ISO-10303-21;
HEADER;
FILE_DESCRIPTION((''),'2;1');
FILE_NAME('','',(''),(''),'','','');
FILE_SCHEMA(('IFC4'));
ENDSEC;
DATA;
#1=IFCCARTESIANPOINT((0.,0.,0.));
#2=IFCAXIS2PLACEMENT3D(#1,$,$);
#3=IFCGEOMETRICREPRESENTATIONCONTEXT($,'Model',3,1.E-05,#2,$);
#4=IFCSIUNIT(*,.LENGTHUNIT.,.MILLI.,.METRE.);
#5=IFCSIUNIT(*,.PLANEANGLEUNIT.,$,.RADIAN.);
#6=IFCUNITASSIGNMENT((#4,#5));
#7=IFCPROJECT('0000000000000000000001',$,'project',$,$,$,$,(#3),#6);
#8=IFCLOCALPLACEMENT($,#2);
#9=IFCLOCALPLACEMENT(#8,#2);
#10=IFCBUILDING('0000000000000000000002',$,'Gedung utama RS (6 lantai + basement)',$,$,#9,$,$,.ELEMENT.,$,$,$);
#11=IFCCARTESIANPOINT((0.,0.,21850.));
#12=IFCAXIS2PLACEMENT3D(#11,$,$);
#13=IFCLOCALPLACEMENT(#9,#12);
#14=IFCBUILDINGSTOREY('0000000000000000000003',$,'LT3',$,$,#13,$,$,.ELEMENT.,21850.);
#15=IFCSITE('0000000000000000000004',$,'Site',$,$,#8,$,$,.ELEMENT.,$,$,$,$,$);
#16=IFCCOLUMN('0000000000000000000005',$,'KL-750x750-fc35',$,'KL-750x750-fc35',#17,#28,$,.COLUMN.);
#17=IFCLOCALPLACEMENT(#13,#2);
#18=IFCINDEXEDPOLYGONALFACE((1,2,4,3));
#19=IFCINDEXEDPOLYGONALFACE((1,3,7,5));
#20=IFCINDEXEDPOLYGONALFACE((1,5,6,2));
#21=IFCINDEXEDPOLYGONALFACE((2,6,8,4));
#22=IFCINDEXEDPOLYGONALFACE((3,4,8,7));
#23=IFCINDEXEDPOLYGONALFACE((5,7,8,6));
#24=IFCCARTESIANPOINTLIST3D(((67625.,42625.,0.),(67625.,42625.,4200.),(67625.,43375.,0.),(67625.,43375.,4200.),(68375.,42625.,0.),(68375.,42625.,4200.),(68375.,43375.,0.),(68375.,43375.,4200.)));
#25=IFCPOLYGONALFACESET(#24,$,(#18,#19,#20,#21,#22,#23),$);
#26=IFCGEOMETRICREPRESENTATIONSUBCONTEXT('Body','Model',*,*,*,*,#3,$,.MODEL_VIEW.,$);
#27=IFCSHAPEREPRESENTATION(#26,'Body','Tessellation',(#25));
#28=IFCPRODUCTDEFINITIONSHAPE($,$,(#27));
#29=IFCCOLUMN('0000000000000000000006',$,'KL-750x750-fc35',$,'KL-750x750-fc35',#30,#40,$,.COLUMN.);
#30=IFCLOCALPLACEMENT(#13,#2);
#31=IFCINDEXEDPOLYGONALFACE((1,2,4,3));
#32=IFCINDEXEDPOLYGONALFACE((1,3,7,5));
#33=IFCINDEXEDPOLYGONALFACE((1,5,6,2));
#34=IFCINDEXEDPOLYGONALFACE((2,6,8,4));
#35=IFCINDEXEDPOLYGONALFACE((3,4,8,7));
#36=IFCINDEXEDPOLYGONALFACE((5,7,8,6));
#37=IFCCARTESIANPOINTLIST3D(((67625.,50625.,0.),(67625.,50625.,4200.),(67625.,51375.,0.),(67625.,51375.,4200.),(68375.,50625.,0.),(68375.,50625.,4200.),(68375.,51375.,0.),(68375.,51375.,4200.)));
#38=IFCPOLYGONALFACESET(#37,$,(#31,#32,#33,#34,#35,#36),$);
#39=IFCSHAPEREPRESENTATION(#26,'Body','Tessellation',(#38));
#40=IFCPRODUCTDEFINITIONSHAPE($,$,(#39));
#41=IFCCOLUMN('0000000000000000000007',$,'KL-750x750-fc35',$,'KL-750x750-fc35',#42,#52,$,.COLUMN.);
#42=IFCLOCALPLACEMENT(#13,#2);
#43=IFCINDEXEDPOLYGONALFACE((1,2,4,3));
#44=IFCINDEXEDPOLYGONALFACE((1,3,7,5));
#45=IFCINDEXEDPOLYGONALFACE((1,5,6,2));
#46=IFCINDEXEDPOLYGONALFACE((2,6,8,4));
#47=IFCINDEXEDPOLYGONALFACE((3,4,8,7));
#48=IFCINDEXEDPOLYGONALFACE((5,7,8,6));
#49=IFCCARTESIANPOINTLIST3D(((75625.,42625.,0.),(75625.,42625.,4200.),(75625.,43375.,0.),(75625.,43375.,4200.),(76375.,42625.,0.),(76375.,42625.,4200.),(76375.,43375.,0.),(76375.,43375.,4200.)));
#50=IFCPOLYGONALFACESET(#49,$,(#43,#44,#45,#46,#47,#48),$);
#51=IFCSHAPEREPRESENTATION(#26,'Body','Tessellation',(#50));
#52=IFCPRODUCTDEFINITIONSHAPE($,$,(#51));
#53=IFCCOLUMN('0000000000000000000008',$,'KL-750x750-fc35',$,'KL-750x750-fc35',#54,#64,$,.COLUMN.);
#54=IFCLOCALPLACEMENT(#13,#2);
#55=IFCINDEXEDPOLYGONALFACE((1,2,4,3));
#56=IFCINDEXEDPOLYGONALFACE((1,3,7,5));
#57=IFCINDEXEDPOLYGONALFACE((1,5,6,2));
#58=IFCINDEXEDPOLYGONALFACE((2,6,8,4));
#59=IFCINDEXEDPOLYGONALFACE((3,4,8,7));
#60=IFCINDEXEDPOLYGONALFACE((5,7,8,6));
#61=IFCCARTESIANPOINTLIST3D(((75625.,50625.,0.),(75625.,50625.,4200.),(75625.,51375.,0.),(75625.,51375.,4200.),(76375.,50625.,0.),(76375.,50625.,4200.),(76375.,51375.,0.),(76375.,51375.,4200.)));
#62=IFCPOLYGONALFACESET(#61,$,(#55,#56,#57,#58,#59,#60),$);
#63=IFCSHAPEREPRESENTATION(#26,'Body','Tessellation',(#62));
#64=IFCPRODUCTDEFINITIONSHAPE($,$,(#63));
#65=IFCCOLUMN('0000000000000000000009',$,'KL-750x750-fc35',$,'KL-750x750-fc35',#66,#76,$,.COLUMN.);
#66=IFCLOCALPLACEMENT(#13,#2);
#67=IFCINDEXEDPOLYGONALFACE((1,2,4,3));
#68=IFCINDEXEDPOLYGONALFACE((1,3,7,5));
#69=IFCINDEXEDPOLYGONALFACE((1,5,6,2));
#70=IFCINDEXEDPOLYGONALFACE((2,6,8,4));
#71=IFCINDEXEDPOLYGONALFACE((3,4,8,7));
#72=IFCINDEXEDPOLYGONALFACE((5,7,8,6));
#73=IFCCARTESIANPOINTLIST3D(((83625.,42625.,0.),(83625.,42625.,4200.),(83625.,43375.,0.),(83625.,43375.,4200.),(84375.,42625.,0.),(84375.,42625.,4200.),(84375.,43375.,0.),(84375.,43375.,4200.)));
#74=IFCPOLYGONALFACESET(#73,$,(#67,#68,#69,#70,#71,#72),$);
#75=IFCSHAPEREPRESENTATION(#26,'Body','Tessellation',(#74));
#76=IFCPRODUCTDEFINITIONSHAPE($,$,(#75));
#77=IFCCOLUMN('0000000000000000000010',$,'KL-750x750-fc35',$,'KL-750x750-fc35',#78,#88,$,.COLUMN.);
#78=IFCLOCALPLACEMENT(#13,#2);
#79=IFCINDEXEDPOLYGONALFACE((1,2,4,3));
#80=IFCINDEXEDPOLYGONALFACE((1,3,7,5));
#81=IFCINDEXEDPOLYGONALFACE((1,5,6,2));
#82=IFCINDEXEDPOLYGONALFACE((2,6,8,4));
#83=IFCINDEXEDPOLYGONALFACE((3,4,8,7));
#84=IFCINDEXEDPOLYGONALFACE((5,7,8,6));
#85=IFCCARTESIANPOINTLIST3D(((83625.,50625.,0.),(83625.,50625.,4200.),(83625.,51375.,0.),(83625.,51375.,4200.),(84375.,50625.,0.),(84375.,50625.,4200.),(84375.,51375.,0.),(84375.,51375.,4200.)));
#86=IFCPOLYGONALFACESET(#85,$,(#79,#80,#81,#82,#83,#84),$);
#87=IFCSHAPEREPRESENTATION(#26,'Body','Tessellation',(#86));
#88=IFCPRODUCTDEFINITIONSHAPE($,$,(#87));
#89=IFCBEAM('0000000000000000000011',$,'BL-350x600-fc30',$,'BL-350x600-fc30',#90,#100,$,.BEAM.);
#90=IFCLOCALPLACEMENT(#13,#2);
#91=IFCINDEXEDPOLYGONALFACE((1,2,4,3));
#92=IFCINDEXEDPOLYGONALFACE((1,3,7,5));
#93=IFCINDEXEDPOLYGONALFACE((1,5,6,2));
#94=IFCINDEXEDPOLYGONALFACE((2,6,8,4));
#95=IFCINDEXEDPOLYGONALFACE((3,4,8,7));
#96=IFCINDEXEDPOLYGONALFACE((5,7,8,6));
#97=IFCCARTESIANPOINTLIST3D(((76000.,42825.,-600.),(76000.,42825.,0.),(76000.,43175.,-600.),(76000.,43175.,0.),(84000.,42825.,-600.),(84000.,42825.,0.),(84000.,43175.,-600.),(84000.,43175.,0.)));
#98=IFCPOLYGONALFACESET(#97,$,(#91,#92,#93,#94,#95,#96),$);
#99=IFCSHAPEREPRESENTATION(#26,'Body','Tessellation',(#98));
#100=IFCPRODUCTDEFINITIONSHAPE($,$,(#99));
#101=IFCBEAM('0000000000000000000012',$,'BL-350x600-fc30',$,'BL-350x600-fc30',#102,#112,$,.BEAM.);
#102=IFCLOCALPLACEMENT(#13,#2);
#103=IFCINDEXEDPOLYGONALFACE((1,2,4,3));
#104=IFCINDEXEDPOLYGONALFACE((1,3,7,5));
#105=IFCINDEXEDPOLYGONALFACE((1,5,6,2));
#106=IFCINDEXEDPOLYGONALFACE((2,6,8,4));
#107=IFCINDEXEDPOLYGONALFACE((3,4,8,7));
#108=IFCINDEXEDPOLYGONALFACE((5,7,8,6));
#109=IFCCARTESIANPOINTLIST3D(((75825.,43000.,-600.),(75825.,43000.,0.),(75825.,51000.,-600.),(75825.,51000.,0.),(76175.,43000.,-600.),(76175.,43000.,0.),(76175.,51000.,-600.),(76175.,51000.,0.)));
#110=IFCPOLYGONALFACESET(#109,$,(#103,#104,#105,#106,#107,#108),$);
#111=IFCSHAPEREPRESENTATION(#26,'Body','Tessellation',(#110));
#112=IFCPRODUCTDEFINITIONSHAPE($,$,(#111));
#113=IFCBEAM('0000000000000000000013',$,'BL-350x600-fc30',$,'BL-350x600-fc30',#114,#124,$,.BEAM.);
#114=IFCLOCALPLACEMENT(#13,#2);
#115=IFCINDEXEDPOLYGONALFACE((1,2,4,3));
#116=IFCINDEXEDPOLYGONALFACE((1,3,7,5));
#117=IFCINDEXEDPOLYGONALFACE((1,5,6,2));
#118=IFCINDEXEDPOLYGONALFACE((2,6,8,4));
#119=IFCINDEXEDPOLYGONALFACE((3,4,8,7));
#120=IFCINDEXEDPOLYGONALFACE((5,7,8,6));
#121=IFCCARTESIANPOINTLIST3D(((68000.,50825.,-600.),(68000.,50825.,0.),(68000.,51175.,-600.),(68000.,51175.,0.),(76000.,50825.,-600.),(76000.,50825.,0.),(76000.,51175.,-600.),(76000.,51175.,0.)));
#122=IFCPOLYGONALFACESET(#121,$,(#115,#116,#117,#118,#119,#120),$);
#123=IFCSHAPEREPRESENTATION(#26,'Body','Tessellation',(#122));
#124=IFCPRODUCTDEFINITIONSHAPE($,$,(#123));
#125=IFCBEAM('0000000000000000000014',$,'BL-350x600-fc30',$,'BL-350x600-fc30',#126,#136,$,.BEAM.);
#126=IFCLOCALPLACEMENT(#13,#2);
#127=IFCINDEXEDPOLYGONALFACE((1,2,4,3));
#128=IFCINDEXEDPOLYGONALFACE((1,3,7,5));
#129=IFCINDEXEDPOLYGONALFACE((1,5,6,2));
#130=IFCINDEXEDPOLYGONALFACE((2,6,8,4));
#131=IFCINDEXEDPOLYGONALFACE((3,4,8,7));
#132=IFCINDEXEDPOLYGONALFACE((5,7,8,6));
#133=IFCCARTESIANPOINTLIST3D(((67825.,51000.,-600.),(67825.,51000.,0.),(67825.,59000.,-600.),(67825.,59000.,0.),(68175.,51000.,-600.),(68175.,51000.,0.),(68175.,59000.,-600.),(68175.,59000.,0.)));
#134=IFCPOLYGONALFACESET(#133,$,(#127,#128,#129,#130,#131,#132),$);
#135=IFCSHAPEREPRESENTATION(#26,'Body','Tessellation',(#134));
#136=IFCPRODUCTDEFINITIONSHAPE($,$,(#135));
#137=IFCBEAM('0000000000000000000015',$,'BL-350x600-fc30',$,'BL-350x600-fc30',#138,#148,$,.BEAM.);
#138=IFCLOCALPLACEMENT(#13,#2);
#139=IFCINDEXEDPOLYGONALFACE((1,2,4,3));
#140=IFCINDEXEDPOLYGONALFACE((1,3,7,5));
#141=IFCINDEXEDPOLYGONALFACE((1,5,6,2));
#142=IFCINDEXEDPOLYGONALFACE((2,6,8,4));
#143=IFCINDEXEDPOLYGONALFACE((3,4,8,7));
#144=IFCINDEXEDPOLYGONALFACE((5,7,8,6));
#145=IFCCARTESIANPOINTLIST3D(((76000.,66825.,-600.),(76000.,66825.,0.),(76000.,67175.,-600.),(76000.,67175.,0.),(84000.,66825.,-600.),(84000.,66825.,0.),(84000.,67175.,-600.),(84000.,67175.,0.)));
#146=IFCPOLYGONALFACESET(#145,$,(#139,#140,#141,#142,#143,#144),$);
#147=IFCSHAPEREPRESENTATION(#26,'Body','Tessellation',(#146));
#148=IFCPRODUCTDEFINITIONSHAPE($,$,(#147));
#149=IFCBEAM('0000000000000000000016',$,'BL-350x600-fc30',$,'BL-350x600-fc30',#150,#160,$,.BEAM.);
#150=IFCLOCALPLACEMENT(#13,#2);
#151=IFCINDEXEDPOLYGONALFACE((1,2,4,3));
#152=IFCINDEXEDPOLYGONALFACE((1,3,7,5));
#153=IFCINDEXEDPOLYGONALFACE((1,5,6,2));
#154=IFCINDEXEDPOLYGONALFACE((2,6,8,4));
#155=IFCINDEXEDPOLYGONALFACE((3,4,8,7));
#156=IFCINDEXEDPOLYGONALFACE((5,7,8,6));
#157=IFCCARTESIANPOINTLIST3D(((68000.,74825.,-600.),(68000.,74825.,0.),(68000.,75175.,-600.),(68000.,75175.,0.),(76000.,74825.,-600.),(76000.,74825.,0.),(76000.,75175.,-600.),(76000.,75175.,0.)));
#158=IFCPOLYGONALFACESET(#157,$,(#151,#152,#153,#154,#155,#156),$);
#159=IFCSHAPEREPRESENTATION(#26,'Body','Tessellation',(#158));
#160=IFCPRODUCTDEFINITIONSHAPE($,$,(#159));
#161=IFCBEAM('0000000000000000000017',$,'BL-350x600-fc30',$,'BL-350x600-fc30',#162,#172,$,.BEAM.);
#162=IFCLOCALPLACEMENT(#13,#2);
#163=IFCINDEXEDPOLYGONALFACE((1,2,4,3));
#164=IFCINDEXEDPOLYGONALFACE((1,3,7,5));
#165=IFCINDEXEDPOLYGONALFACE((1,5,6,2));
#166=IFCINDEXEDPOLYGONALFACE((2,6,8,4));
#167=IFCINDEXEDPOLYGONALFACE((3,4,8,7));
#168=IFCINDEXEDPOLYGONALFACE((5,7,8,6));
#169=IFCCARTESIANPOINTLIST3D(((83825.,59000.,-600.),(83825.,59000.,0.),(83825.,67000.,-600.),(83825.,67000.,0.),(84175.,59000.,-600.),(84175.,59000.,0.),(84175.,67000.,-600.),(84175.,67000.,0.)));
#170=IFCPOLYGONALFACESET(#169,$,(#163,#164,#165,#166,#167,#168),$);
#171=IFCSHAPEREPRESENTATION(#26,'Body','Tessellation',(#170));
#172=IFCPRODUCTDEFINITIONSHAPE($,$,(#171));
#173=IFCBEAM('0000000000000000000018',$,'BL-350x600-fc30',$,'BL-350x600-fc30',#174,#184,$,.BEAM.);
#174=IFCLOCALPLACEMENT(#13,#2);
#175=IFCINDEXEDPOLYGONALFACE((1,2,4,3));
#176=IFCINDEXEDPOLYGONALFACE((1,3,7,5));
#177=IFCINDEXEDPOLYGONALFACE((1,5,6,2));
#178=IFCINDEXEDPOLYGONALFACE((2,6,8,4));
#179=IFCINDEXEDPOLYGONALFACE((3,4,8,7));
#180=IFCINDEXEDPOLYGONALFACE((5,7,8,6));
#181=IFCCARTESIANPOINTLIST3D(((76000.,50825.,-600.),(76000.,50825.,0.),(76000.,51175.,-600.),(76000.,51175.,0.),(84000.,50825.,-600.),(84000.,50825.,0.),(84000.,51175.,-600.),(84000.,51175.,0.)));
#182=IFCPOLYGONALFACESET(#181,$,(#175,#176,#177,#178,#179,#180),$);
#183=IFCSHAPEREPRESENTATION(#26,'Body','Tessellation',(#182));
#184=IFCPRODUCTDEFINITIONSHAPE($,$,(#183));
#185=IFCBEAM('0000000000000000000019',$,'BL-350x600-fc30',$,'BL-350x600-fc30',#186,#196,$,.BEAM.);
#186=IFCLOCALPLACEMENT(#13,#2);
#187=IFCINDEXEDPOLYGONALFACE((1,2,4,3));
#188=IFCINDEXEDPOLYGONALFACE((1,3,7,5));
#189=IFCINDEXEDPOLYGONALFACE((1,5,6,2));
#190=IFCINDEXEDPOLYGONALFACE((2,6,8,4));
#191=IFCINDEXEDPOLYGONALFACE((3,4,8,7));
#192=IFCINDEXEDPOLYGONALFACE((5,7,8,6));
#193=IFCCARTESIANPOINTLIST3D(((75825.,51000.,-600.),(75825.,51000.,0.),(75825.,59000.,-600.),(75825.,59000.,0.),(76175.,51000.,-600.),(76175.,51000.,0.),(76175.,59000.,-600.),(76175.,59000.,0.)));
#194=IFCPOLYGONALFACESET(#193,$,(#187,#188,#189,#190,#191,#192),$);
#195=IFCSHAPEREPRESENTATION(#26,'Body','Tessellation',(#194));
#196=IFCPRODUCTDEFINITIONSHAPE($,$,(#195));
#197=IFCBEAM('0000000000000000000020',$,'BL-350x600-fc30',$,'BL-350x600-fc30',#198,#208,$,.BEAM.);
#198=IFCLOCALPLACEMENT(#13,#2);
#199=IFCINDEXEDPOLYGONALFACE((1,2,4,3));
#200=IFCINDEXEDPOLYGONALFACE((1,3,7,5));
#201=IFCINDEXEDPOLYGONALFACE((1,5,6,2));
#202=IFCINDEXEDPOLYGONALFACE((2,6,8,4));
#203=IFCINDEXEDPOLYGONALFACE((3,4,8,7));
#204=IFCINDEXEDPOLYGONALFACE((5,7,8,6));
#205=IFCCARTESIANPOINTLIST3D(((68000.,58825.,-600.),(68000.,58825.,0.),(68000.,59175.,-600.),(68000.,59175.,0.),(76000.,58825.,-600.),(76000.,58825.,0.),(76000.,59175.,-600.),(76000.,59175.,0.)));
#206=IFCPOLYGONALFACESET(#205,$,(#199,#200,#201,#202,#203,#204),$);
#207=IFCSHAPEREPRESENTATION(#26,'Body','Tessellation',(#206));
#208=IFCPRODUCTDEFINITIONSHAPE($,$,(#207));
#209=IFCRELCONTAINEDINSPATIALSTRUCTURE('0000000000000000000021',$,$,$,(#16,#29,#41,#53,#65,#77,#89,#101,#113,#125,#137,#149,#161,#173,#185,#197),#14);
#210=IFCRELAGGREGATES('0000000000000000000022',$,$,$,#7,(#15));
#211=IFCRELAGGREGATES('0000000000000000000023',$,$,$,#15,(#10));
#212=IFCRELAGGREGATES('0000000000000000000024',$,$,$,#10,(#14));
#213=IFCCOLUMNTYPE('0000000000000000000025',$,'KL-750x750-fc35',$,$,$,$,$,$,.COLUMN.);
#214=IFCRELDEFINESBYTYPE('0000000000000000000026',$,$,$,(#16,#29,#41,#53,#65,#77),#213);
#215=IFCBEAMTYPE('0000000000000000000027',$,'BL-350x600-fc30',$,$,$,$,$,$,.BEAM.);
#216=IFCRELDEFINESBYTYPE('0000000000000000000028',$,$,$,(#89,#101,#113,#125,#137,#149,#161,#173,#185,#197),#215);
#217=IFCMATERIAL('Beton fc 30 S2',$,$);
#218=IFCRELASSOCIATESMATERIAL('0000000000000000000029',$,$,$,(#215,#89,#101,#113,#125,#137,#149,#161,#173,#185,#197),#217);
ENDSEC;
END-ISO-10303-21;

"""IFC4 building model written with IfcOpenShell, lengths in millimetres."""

from ifc_helpers import new_model, si_unit, frame, origin, origin_2d, place, context, subcontext, project, spatial, rectangle, extrude, material, material_profile, profile_set, profile_usage, type_object, element, save


model = new_model("IFC4")

# Units and contexts
model_context = context("Model", 3, precision=1e-05, world=origin())
body_context = subcontext(model_context, "Body", "Model", "MODEL_VIEW")
ifc_project = project(units=[si_unit("LENGTHUNIT", "METRE", prefix="MILLI"), si_unit("PLANEANGLEUNIT", "RADIAN")], contexts=[model_context])

# Site, building, storey
site_placement = place(None, origin())
site = spatial("IfcSite", under=ifc_project, at=site_placement, Name="Site", CompositionType="ELEMENT")
building_placement = place(site_placement, origin())
building = spatial("IfcBuilding", under=site, at=building_placement, Name="Gedung utama RS (6 lantai + basement)", CompositionType="ELEMENT")
storey_placement = place(building_placement, frame((0.0, 0.0, 21850.0)))
storey = spatial("IfcBuildingStorey", under=building, at=storey_placement, Name="LT3", CompositionType="ELEMENT", Elevation=21850.0)

# Columns
ifc_material_profile_1 = material_profile(None, rectangle(XDim=750.0, YDim=750.0, at=origin_2d()), Name="KL-750x750-fc35")
ifc_profile_set_1 = profile_set([ifc_material_profile_1], Name="KL-750x750-fc35")
ifc_profile_usage_1 = profile_usage(ifc_profile_set_1, cardinal=5)
column_type = type_object("IfcColumnType", Name="KL-750x750-fc35", PredefinedType="COLUMN", material=ifc_profile_set_1)
for number, where, z_axis, x_axis, name in (
    (1, (68000.0, 43000.0, 0.0), (0.0, 0.0, 1.0), (1.0, 0.0, 0.0), "KL-750x750-fc35"),
    (2, (68000.0, 51000.0, 0.0), (0.0, 0.0, 1.0), (1.0, 0.0, 0.0), "KL-750x750-fc35"),
    (3, (76000.0, 43000.0, 0.0), (0.0, 0.0, 1.0), (1.0, 0.0, 0.0), "KL-750x750-fc35"),
    (4, (76000.0, 51000.0, 0.0), (0.0, 0.0, 1.0), (1.0, 0.0, 0.0), "KL-750x750-fc35"),
    (5, (84000.0, 43000.0, 0.0), (0.0, 0.0, 1.0), (1.0, 0.0, 0.0), "KL-750x750-fc35"),
    (6, (84000.0, 51000.0, 0.0), (0.0, 0.0, 1.0), (1.0, 0.0, 0.0), "KL-750x750-fc35"),
):
    element("IfcColumn", number, at=place(storey_placement, frame(where, z_axis=z_axis, x_axis=x_axis)), inside=storey, type_object=column_type, material=ifc_profile_usage_1, Name=name, ObjectType="KL-750x750-fc35", PredefinedType="COLUMN", context=body_context, shape_type="SweptSolid", body=[
        extrude(rectangle(XDim=750.0, YDim=750.0, at=origin_2d()), origin(), (0.0, 0.0, 1.0), 4200.0),
    ])

# Beams
ifc_material = material(Name="Beton fc 30 S2")
ifc_material_profile_2 = material_profile(ifc_material, rectangle(XDim=350.0, YDim=600.0, at=origin_2d()), Name="BL-350x600-fc30")
ifc_profile_set_2 = profile_set([ifc_material_profile_2], Name="BL-350x600-fc30")
ifc_profile_usage_2 = profile_usage(ifc_profile_set_2, cardinal=8)
beam_type_1 = type_object("IfcBeamType", Name="BL-350x600-fc30", PredefinedType="BEAM", material=ifc_profile_set_2)
beam_1_placement = place(storey_placement, frame((76000.0, 43000.0, -300.0)))
element("IfcBeam", 7, at=beam_1_placement, inside=storey, type_object=beam_type_1, material=ifc_profile_usage_2, Name="BL-350x600-fc30", ObjectType="BL-350x600-fc30", PredefinedType="BEAM", context=body_context, shape_type="SweptSolid", body=[
    extrude(rectangle(XDim=350.0, YDim=600.0, at=origin_2d()), frame((0.0, 0.0, 0.0), z_axis=(1.0, 0.0, 0.0), x_axis=(0.0, 1.0, 0.0)), (0.0, 0.0, 1.0), 8000.0),
])
beam_2_placement = place(storey_placement, frame((76000.0, 43000.0, -300.0)))
element("IfcBeam", 8, at=beam_2_placement, inside=storey, type_object=beam_type_1, material=ifc_profile_usage_2, Name="BL-350x600-fc30", ObjectType="BL-350x600-fc30", PredefinedType="BEAM", context=body_context, shape_type="SweptSolid", body=[
    extrude(rectangle(XDim=350.0, YDim=600.0, at=origin_2d()), frame((0.0, 0.0, 0.0), z_axis=(0.0, 1.0, 0.0), x_axis=(-1.0, 0.0, 0.0)), (0.0, 0.0, 1.0), 8000.0),
])
beam_3_placement = place(storey_placement, frame((68000.0, 51000.0, -300.0)))
element("IfcBeam", 9, at=beam_3_placement, inside=storey, type_object=beam_type_1, material=ifc_profile_usage_2, Name="BL-350x600-fc30", ObjectType="BL-350x600-fc30", PredefinedType="BEAM", context=body_context, shape_type="SweptSolid", body=[
    extrude(rectangle(XDim=350.0, YDim=600.0, at=origin_2d()), frame((0.0, 0.0, 0.0), z_axis=(1.0, 0.0, 0.0), x_axis=(0.0, 1.0, 0.0)), (0.0, 0.0, 1.0), 8000.0),
])
beam_4_placement = place(storey_placement, frame((68000.0, 51000.0, -300.0)))
element("IfcBeam", 10, at=beam_4_placement, inside=storey, type_object=beam_type_1, material=ifc_profile_usage_2, Name="BL-350x600-fc30", ObjectType="BL-350x600-fc30", PredefinedType="BEAM", context=body_context, shape_type="SweptSolid", body=[
    extrude(rectangle(XDim=350.0, YDim=600.0, at=origin_2d()), frame((0.0, 0.0, 0.0), z_axis=(0.0, 1.0, 0.0), x_axis=(-1.0, 0.0, 0.0)), (0.0, 0.0, 1.0), 8000.0),
])
for number, where, name in (
    (11, (76000.0, 67000.0, -300.0), "BL-350x600-fc30"),
    (12, (68000.0, 75000.0, -300.0), "BL-350x600-fc30"),
):
    element("IfcBeam", number, at=place(storey_placement, frame(where)), inside=storey, type_object=beam_type_1, material=ifc_profile_usage_2, Name=name, ObjectType="BL-350x600-fc30", PredefinedType="BEAM", context=body_context, shape_type="SweptSolid", body=[
        extrude(rectangle(XDim=350.0, YDim=600.0, at=origin_2d()), frame((0.0, 0.0, 0.0), z_axis=(1.0, 0.0, 0.0), x_axis=(0.0, 1.0, 0.0)), (0.0, 0.0, 1.0), 8000.0),
    ])
beam_5_placement = place(storey_placement, frame((84000.0, 59000.0, -300.0)))
element("IfcBeam", 13, at=beam_5_placement, inside=storey, type_object=beam_type_1, material=ifc_profile_usage_2, Name="BL-350x600-fc30", ObjectType="BL-350x600-fc30", PredefinedType="BEAM", context=body_context, shape_type="SweptSolid", body=[
    extrude(rectangle(XDim=350.0, YDim=600.0, at=origin_2d()), frame((0.0, 0.0, 0.0), z_axis=(0.0, 1.0, 0.0), x_axis=(-1.0, 0.0, 0.0)), (0.0, 0.0, 1.0), 8000.0),
])
beam_6_placement = place(storey_placement, frame((76000.0, 51000.0, -300.0)))
element("IfcBeam", 14, at=beam_6_placement, inside=storey, type_object=beam_type_1, material=ifc_profile_usage_2, Name="BL-350x600-fc30", ObjectType="BL-350x600-fc30", PredefinedType="BEAM", context=body_context, shape_type="SweptSolid", body=[
    extrude(rectangle(XDim=350.0, YDim=600.0, at=origin_2d()), frame((0.0, 0.0, 0.0), z_axis=(1.0, 0.0, 0.0), x_axis=(0.0, 1.0, 0.0)), (0.0, 0.0, 1.0), 8000.0),
])
beam_7_placement = place(storey_placement, frame((76000.0, 51000.0, -300.0)))
element("IfcBeam", 15, at=beam_7_placement, inside=storey, type_object=beam_type_1, material=ifc_profile_usage_2, Name="BL-350x600-fc30", ObjectType="BL-350x600-fc30", PredefinedType="BEAM", context=body_context, shape_type="SweptSolid", body=[
    extrude(rectangle(XDim=350.0, YDim=600.0, at=origin_2d()), frame((0.0, 0.0, 0.0), z_axis=(0.0, 1.0, 0.0), x_axis=(-1.0, 0.0, 0.0)), (0.0, 0.0, 1.0), 8000.0),
])
beam_8_placement = place(storey_placement, frame((68000.0, 59000.0, -300.0)))
element("IfcBeam", 16, at=beam_8_placement, inside=storey, type_object=beam_type_1, material=ifc_profile_usage_2, Name="BL-350x600-fc30", ObjectType="BL-350x600-fc30", PredefinedType="BEAM", context=body_context, shape_type="SweptSolid", body=[
    extrude(rectangle(XDim=350.0, YDim=600.0, at=origin_2d()), frame((0.0, 0.0, 0.0), z_axis=(1.0, 0.0, 0.0), x_axis=(0.0, 1.0, 0.0)), (0.0, 0.0, 1.0), 8000.0),
])

save(model, "model.ifc")
